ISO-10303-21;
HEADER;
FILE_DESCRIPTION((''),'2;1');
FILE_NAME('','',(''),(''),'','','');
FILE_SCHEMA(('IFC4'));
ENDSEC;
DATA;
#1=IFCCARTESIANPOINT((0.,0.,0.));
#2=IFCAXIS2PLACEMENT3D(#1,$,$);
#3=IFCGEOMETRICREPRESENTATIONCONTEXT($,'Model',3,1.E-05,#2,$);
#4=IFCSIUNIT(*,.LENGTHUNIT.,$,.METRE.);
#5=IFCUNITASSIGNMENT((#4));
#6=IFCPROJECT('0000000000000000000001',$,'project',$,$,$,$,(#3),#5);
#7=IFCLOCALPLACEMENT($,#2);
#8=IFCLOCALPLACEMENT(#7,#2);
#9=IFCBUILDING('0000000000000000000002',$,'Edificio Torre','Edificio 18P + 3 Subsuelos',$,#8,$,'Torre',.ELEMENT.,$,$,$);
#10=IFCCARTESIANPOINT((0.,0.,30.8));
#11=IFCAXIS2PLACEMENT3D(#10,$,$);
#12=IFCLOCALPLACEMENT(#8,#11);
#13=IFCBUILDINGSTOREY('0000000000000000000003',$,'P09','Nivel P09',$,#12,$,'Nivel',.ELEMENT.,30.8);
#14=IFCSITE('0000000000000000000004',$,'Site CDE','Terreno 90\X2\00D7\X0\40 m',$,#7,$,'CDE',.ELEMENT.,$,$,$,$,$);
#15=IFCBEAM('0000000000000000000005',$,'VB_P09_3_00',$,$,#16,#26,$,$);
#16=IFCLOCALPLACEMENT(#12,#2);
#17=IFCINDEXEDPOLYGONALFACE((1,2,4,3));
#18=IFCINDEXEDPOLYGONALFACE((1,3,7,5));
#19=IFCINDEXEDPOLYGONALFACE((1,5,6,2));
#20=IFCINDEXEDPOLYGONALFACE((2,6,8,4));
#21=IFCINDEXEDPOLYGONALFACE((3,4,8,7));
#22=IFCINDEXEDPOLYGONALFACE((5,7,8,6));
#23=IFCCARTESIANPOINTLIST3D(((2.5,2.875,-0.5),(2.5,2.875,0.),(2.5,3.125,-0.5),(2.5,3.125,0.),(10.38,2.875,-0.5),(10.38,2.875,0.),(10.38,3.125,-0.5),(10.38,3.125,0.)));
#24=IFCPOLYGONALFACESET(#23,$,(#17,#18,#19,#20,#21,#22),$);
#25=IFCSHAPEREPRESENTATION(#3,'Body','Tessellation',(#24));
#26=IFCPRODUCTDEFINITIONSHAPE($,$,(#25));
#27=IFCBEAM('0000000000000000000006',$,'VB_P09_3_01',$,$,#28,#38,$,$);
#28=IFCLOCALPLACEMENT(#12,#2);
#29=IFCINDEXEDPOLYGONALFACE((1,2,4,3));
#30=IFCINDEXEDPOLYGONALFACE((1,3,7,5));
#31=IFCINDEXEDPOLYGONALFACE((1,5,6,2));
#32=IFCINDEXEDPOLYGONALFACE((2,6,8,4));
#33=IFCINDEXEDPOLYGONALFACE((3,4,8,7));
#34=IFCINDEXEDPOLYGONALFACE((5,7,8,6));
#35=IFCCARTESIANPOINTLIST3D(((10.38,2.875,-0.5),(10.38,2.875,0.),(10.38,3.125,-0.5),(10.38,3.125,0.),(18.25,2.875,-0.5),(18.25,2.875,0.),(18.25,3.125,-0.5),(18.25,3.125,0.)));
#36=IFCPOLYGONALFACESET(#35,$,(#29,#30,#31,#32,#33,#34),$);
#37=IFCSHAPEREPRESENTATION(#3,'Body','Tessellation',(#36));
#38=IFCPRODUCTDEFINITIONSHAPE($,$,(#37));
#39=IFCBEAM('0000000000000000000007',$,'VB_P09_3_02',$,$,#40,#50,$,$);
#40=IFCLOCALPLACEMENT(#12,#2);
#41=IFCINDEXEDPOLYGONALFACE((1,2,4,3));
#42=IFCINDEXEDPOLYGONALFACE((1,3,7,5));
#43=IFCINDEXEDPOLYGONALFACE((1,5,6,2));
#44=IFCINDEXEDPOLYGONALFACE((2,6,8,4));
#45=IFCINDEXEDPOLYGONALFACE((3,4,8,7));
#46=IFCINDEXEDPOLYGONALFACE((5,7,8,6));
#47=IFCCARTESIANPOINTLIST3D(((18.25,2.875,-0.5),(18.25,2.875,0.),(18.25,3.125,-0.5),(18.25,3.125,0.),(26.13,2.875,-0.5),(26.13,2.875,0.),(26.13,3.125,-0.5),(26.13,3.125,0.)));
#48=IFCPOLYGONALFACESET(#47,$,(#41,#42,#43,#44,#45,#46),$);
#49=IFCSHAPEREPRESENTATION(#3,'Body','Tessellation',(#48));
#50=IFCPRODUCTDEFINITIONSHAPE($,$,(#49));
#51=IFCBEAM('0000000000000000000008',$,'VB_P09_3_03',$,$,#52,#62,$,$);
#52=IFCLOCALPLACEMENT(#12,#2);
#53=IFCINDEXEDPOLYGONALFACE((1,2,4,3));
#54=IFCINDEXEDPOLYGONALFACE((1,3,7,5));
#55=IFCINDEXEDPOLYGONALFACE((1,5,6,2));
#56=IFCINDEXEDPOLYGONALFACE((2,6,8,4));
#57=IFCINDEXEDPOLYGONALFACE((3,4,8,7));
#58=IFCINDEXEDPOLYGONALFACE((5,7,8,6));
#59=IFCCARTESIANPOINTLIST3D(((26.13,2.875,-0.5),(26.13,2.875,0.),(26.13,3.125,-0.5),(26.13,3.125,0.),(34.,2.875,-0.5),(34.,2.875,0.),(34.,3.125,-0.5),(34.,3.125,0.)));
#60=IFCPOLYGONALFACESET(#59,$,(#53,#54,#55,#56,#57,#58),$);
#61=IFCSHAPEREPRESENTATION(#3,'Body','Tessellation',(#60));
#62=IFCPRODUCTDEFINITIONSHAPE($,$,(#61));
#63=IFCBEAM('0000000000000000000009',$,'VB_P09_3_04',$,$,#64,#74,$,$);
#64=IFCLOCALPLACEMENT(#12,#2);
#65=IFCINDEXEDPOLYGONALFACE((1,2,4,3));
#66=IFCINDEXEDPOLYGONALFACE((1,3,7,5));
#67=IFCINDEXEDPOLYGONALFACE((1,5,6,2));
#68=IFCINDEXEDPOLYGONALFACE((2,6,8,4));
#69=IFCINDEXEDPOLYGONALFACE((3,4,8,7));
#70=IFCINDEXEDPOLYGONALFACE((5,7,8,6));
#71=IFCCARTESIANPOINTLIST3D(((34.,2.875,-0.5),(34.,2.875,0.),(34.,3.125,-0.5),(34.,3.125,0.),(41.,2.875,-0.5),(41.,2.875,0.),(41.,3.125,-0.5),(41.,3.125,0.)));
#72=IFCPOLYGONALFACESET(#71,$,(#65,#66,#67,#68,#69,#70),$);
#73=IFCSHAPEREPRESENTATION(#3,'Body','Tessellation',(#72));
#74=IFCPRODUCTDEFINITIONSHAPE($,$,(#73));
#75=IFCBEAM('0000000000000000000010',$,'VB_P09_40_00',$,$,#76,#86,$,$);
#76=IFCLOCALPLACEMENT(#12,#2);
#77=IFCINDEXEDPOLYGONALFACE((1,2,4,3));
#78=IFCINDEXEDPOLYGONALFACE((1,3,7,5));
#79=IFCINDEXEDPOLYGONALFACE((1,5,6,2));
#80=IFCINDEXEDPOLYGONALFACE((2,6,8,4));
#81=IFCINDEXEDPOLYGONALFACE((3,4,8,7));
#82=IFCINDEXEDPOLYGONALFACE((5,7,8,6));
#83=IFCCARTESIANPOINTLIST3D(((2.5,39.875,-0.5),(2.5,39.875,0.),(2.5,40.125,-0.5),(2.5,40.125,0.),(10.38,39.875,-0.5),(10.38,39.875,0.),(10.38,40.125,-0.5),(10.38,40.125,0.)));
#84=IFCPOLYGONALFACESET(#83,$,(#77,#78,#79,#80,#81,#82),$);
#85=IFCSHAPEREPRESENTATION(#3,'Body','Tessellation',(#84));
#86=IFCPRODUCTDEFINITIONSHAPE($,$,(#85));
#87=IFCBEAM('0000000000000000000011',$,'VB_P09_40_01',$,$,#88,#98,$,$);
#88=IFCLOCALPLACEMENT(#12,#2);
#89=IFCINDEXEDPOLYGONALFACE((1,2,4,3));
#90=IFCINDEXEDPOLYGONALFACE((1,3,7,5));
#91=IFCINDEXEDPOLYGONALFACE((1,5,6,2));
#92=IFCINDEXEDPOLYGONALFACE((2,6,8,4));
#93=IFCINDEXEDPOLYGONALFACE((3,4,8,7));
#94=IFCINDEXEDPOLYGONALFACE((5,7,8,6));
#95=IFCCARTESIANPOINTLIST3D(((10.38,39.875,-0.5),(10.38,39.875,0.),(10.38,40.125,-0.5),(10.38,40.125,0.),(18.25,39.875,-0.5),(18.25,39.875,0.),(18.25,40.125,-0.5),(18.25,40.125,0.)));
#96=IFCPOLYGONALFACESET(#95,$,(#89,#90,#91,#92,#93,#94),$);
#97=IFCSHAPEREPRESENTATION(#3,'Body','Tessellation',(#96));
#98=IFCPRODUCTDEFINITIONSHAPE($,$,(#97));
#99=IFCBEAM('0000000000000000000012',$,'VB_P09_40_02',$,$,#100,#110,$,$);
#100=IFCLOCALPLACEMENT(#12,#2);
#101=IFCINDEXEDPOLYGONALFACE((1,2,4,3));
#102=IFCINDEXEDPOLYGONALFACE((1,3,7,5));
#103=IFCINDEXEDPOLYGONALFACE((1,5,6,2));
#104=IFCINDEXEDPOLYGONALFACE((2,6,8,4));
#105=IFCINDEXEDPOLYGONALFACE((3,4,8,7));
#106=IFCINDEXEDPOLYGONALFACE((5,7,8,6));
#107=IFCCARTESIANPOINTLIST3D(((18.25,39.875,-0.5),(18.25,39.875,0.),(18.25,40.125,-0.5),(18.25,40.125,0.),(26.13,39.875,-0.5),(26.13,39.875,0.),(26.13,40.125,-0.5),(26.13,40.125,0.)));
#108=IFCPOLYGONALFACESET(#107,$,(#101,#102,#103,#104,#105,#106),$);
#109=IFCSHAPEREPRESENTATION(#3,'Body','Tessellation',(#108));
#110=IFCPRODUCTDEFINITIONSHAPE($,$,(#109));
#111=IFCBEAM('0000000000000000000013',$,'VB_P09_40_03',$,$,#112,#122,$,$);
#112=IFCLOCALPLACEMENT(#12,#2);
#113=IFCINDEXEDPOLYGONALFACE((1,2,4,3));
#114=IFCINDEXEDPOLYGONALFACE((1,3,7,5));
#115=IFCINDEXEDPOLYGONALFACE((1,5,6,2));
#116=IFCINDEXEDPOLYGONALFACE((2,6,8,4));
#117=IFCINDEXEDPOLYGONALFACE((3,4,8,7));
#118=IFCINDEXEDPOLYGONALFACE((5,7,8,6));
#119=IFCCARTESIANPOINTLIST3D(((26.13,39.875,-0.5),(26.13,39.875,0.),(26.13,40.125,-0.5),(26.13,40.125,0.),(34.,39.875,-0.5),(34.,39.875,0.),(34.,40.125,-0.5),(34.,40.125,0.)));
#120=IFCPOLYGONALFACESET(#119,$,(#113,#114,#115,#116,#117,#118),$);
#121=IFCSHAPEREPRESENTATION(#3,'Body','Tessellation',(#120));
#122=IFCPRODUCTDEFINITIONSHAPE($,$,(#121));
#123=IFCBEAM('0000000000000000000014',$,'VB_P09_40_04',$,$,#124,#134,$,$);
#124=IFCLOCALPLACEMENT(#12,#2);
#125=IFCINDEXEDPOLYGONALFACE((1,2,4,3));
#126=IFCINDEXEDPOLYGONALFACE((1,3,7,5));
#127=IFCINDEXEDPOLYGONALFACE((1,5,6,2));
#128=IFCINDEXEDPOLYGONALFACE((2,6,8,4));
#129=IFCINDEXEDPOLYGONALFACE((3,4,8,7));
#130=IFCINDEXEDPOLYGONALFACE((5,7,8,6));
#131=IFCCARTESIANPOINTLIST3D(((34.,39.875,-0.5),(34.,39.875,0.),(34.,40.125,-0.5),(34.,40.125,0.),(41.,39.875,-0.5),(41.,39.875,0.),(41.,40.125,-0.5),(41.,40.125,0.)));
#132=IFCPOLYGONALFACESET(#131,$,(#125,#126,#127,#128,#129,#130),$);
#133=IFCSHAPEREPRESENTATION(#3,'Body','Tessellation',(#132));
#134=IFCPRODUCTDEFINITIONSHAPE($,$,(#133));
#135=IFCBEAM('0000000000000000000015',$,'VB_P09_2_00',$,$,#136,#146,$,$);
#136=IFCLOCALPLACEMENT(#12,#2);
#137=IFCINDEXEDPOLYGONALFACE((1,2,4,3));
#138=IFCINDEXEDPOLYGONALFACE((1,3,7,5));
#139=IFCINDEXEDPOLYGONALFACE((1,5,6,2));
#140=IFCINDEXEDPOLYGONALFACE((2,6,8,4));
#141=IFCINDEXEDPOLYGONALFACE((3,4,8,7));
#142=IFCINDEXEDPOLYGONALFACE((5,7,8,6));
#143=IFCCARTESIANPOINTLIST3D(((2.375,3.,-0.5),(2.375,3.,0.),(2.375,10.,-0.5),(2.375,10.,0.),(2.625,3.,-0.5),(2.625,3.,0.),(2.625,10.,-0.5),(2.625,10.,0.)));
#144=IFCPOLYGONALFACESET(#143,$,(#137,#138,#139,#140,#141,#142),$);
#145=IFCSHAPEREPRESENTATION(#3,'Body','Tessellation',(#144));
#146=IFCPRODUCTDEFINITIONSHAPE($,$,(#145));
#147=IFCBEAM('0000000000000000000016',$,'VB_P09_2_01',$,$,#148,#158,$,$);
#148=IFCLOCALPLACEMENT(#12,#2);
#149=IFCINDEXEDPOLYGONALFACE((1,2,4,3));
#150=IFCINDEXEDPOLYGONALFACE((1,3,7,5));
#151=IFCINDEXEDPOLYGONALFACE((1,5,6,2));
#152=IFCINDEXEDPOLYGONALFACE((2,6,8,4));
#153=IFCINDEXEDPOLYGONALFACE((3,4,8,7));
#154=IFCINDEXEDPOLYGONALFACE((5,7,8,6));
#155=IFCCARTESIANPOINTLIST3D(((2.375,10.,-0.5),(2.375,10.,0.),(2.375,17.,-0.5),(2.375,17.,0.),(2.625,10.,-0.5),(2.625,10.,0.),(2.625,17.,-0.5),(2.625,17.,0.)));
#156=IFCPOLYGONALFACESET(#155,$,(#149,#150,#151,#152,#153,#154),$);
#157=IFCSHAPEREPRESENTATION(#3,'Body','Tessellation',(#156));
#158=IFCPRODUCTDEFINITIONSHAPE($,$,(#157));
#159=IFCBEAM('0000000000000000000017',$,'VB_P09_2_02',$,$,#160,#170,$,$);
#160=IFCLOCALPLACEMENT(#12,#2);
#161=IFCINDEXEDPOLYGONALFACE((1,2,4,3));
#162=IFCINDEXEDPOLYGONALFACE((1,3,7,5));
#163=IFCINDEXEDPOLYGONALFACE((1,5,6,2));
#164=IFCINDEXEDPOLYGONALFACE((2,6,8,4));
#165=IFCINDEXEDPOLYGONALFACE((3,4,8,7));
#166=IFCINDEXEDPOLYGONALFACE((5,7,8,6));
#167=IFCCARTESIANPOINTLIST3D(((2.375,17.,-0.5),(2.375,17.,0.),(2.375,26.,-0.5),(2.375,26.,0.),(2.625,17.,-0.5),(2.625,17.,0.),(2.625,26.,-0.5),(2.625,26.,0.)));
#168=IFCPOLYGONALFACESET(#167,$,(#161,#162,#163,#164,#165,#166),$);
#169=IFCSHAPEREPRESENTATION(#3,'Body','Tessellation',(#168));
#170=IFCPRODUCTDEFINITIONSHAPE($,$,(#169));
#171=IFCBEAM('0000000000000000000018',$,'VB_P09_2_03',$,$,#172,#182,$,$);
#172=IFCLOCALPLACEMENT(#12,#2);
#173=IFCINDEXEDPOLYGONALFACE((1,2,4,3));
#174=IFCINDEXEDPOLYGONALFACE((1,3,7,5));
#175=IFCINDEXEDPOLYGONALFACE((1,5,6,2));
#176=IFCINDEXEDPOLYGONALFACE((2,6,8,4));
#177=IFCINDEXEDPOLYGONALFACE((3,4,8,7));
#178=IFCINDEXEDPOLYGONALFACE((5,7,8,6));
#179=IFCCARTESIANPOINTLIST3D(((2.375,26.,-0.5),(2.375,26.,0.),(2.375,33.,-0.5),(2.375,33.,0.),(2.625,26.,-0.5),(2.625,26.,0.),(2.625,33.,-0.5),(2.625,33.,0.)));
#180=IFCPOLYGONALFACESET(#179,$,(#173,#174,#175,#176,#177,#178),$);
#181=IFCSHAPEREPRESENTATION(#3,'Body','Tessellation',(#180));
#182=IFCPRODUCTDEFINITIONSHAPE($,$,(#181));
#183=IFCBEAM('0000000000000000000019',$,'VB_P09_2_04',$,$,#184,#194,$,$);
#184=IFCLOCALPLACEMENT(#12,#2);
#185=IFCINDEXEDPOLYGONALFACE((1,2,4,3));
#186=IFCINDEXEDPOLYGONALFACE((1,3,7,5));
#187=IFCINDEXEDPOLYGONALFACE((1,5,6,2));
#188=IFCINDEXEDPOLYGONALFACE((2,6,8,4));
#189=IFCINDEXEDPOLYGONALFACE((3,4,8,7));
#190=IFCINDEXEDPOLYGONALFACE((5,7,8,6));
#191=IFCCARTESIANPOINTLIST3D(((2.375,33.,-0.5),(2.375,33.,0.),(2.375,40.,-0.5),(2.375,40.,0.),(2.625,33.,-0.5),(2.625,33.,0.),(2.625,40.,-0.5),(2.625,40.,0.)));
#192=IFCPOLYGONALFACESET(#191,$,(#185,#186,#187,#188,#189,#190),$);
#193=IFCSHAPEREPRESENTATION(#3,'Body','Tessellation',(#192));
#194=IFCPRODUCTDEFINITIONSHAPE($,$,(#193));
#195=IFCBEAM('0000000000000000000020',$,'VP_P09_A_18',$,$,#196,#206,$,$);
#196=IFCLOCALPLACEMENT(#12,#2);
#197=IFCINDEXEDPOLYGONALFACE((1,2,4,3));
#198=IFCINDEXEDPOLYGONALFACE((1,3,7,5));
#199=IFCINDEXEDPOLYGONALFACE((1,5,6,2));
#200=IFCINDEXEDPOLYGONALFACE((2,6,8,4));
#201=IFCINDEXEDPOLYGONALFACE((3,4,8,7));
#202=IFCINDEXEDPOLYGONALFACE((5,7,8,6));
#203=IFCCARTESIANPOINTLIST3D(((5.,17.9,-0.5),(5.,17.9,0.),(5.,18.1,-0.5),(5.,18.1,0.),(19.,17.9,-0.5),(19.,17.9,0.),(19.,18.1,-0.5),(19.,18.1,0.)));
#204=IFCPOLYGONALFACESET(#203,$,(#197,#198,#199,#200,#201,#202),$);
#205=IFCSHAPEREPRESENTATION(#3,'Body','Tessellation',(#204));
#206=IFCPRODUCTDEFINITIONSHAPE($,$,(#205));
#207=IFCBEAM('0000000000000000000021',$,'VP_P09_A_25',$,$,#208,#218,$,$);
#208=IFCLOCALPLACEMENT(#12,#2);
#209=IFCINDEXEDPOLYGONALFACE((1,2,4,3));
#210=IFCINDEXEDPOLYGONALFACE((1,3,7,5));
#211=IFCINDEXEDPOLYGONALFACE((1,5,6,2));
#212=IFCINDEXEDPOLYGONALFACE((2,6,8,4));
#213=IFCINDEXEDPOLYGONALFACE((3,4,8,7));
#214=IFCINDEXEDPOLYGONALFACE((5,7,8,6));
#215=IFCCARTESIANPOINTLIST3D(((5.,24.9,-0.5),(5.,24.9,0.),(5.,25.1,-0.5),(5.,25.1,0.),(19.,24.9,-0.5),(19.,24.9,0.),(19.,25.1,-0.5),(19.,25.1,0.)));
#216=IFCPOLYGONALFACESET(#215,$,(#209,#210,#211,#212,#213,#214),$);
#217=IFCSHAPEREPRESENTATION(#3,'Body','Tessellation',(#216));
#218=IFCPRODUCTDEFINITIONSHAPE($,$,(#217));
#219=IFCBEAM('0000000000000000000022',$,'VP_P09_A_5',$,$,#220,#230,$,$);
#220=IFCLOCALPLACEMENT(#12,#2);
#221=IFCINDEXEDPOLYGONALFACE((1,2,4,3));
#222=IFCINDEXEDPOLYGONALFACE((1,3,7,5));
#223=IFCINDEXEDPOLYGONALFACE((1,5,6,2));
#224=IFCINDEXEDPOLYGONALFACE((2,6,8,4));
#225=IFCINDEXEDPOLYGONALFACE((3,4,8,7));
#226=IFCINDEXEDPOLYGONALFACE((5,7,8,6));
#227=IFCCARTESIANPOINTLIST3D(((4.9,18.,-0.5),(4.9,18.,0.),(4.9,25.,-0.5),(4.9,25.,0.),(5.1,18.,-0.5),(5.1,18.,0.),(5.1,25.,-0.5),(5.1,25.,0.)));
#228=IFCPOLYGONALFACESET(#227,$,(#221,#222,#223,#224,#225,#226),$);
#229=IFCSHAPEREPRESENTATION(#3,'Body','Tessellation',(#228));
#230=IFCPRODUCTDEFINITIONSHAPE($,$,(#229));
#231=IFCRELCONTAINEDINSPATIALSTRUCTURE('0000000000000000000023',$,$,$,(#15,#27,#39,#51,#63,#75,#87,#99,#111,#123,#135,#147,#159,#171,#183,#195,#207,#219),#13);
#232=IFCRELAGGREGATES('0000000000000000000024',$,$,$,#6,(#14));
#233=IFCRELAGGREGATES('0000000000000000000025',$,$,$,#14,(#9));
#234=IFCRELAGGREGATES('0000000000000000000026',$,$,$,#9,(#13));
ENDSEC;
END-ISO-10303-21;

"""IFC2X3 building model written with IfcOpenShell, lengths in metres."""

from ifc_helpers import new_model, si_unit, frame, origin, origin_2d, place, context, project, spatial, rectangle, extrude, element, save


model = new_model("IFC2X3")

# Units and contexts
model_context = context("Model", 3, precision=1e-05, world=origin())
ifc_project = project(units=[si_unit("LENGTHUNIT", "METRE")], contexts=[model_context])

# Site, building, storey
site_placement = place(None, origin())
site = spatial("IfcSite", under=ifc_project, at=site_placement, Name="Site CDE", Description="Terreno 90×40 m", LongName="CDE", CompositionType="ELEMENT")
building_placement = place(site_placement, origin())
building = spatial("IfcBuilding", under=site, at=building_placement, Name="Edificio Torre", Description="Edificio 18P + 3 Subsuelos", LongName="Torre", CompositionType="ELEMENT")
storey_placement = place(building_placement, frame((0.0, 0.0, 30.8)))
storey = spatial("IfcBuildingStorey", under=building, at=storey_placement, Name="P09", Description="Nivel P09", LongName="Nivel", CompositionType="ELEMENT", Elevation=30.8)

# Beams
beam_1_placement = place(storey_placement, frame((6.44, 3.0, -0.5)))
element("IfcBeam", 1, at=beam_1_placement, inside=storey, Name="VB_P09_3_00", context=model_context, shape_type="SweptSolid", body=[
    extrude(rectangle(XDim=7.88, YDim=0.25, at=origin_2d()), origin(), (0.0, 0.0, 1.0), 0.5),
])
beam_2_placement = place(storey_placement, frame((14.315, 3.0, -0.5)))
element("IfcBeam", 2, at=beam_2_placement, inside=storey, Name="VB_P09_3_01", context=model_context, shape_type="SweptSolid", body=[
    extrude(rectangle(XDim=7.87, YDim=0.25, at=origin_2d()), origin(), (0.0, 0.0, 1.0), 0.5),
])
beam_3_placement = place(storey_placement, frame((22.19, 3.0, -0.5)))
element("IfcBeam", 3, at=beam_3_placement, inside=storey, Name="VB_P09_3_02", context=model_context, shape_type="SweptSolid", body=[
    extrude(rectangle(XDim=7.88, YDim=0.25, at=origin_2d()), origin(), (0.0, 0.0, 1.0), 0.5),
])
beam_4_placement = place(storey_placement, frame((30.065, 3.0, -0.5)))
element("IfcBeam", 4, at=beam_4_placement, inside=storey, Name="VB_P09_3_03", context=model_context, shape_type="SweptSolid", body=[
    extrude(rectangle(XDim=7.87, YDim=0.25, at=origin_2d()), origin(), (0.0, 0.0, 1.0), 0.5),
])
beam_5_placement = place(storey_placement, frame((37.5, 3.0, -0.5)))
element("IfcBeam", 5, at=beam_5_placement, inside=storey, Name="VB_P09_3_04", context=model_context, shape_type="SweptSolid", body=[
    extrude(rectangle(XDim=7.0, YDim=0.25, at=origin_2d()), origin(), (0.0, 0.0, 1.0), 0.5),
])
beam_6_placement = place(storey_placement, frame((6.44, 40.0, -0.5)))
element("IfcBeam", 6, at=beam_6_placement, inside=storey, Name="VB_P09_40_00", context=model_context, shape_type="SweptSolid", body=[
    extrude(rectangle(XDim=7.88, YDim=0.25, at=origin_2d()), origin(), (0.0, 0.0, 1.0), 0.5),
])
beam_7_placement = place(storey_placement, frame((14.315, 40.0, -0.5)))
element("IfcBeam", 7, at=beam_7_placement, inside=storey, Name="VB_P09_40_01", context=model_context, shape_type="SweptSolid", body=[
    extrude(rectangle(XDim=7.87, YDim=0.25, at=origin_2d()), origin(), (0.0, 0.0, 1.0), 0.5),
])
beam_8_placement = place(storey_placement, frame((22.19, 40.0, -0.5)))
element("IfcBeam", 8, at=beam_8_placement, inside=storey, Name="VB_P09_40_02", context=model_context, shape_type="SweptSolid", body=[
    extrude(rectangle(XDim=7.88, YDim=0.25, at=origin_2d()), origin(), (0.0, 0.0, 1.0), 0.5),
])
beam_9_placement = place(storey_placement, frame((30.065, 40.0, -0.5)))
element("IfcBeam", 9, at=beam_9_placement, inside=storey, Name="VB_P09_40_03", context=model_context, shape_type="SweptSolid", body=[
    extrude(rectangle(XDim=7.87, YDim=0.25, at=origin_2d()), origin(), (0.0, 0.0, 1.0), 0.5),
])
beam_10_placement = place(storey_placement, frame((37.5, 40.0, -0.5)))
element("IfcBeam", 10, at=beam_10_placement, inside=storey, Name="VB_P09_40_04", context=model_context, shape_type="SweptSolid", body=[
    extrude(rectangle(XDim=7.0, YDim=0.25, at=origin_2d()), origin(), (0.0, 0.0, 1.0), 0.5),
])
for number, where, name in (
    (11, (2.5, 6.5, -0.5), "VB_P09_2_00"),
    (12, (2.5, 13.5, -0.5), "VB_P09_2_01"),
):
    element("IfcBeam", number, at=place(storey_placement, frame(where)), inside=storey, Name=name, context=model_context, shape_type="SweptSolid", body=[
        extrude(rectangle(XDim=0.25, YDim=7.0, at=origin_2d()), origin(), (0.0, 0.0, 1.0), 0.5),
    ])
beam_11_placement = place(storey_placement, frame((2.5, 21.5, -0.5)))
element("IfcBeam", 13, at=beam_11_placement, inside=storey, Name="VB_P09_2_02", context=model_context, shape_type="SweptSolid", body=[
    extrude(rectangle(XDim=0.25, YDim=9.0, at=origin_2d()), origin(), (0.0, 0.0, 1.0), 0.5),
])
for number, where, name in (
    (14, (2.5, 29.5, -0.5), "VB_P09_2_03"),
    (15, (2.5, 36.5, -0.5), "VB_P09_2_04"),
):
    element("IfcBeam", number, at=place(storey_placement, frame(where)), inside=storey, Name=name, context=model_context, shape_type="SweptSolid", body=[
        extrude(rectangle(XDim=0.25, YDim=7.0, at=origin_2d()), origin(), (0.0, 0.0, 1.0), 0.5),
    ])
for number, where, name in (
    (16, (12.0, 18.0, -0.5), "VP_P09_A_18"),
    (17, (12.0, 25.0, -0.5), "VP_P09_A_25"),
):
    element("IfcBeam", number, at=place(storey_placement, frame(where)), inside=storey, Name=name, context=model_context, shape_type="SweptSolid", body=[
        extrude(rectangle(XDim=14.0, YDim=0.2, at=origin_2d()), origin(), (0.0, 0.0, 1.0), 0.5),
    ])
beam_12_placement = place(storey_placement, frame((5.0, 21.5, -0.5)))
element("IfcBeam", 18, at=beam_12_placement, inside=storey, Name="VP_P09_A_5", context=model_context, shape_type="SweptSolid", body=[
    extrude(rectangle(XDim=0.2, YDim=7.0, at=origin_2d()), origin(), (0.0, 0.0, 1.0), 0.5),
])

save(model, "model.ifc")
